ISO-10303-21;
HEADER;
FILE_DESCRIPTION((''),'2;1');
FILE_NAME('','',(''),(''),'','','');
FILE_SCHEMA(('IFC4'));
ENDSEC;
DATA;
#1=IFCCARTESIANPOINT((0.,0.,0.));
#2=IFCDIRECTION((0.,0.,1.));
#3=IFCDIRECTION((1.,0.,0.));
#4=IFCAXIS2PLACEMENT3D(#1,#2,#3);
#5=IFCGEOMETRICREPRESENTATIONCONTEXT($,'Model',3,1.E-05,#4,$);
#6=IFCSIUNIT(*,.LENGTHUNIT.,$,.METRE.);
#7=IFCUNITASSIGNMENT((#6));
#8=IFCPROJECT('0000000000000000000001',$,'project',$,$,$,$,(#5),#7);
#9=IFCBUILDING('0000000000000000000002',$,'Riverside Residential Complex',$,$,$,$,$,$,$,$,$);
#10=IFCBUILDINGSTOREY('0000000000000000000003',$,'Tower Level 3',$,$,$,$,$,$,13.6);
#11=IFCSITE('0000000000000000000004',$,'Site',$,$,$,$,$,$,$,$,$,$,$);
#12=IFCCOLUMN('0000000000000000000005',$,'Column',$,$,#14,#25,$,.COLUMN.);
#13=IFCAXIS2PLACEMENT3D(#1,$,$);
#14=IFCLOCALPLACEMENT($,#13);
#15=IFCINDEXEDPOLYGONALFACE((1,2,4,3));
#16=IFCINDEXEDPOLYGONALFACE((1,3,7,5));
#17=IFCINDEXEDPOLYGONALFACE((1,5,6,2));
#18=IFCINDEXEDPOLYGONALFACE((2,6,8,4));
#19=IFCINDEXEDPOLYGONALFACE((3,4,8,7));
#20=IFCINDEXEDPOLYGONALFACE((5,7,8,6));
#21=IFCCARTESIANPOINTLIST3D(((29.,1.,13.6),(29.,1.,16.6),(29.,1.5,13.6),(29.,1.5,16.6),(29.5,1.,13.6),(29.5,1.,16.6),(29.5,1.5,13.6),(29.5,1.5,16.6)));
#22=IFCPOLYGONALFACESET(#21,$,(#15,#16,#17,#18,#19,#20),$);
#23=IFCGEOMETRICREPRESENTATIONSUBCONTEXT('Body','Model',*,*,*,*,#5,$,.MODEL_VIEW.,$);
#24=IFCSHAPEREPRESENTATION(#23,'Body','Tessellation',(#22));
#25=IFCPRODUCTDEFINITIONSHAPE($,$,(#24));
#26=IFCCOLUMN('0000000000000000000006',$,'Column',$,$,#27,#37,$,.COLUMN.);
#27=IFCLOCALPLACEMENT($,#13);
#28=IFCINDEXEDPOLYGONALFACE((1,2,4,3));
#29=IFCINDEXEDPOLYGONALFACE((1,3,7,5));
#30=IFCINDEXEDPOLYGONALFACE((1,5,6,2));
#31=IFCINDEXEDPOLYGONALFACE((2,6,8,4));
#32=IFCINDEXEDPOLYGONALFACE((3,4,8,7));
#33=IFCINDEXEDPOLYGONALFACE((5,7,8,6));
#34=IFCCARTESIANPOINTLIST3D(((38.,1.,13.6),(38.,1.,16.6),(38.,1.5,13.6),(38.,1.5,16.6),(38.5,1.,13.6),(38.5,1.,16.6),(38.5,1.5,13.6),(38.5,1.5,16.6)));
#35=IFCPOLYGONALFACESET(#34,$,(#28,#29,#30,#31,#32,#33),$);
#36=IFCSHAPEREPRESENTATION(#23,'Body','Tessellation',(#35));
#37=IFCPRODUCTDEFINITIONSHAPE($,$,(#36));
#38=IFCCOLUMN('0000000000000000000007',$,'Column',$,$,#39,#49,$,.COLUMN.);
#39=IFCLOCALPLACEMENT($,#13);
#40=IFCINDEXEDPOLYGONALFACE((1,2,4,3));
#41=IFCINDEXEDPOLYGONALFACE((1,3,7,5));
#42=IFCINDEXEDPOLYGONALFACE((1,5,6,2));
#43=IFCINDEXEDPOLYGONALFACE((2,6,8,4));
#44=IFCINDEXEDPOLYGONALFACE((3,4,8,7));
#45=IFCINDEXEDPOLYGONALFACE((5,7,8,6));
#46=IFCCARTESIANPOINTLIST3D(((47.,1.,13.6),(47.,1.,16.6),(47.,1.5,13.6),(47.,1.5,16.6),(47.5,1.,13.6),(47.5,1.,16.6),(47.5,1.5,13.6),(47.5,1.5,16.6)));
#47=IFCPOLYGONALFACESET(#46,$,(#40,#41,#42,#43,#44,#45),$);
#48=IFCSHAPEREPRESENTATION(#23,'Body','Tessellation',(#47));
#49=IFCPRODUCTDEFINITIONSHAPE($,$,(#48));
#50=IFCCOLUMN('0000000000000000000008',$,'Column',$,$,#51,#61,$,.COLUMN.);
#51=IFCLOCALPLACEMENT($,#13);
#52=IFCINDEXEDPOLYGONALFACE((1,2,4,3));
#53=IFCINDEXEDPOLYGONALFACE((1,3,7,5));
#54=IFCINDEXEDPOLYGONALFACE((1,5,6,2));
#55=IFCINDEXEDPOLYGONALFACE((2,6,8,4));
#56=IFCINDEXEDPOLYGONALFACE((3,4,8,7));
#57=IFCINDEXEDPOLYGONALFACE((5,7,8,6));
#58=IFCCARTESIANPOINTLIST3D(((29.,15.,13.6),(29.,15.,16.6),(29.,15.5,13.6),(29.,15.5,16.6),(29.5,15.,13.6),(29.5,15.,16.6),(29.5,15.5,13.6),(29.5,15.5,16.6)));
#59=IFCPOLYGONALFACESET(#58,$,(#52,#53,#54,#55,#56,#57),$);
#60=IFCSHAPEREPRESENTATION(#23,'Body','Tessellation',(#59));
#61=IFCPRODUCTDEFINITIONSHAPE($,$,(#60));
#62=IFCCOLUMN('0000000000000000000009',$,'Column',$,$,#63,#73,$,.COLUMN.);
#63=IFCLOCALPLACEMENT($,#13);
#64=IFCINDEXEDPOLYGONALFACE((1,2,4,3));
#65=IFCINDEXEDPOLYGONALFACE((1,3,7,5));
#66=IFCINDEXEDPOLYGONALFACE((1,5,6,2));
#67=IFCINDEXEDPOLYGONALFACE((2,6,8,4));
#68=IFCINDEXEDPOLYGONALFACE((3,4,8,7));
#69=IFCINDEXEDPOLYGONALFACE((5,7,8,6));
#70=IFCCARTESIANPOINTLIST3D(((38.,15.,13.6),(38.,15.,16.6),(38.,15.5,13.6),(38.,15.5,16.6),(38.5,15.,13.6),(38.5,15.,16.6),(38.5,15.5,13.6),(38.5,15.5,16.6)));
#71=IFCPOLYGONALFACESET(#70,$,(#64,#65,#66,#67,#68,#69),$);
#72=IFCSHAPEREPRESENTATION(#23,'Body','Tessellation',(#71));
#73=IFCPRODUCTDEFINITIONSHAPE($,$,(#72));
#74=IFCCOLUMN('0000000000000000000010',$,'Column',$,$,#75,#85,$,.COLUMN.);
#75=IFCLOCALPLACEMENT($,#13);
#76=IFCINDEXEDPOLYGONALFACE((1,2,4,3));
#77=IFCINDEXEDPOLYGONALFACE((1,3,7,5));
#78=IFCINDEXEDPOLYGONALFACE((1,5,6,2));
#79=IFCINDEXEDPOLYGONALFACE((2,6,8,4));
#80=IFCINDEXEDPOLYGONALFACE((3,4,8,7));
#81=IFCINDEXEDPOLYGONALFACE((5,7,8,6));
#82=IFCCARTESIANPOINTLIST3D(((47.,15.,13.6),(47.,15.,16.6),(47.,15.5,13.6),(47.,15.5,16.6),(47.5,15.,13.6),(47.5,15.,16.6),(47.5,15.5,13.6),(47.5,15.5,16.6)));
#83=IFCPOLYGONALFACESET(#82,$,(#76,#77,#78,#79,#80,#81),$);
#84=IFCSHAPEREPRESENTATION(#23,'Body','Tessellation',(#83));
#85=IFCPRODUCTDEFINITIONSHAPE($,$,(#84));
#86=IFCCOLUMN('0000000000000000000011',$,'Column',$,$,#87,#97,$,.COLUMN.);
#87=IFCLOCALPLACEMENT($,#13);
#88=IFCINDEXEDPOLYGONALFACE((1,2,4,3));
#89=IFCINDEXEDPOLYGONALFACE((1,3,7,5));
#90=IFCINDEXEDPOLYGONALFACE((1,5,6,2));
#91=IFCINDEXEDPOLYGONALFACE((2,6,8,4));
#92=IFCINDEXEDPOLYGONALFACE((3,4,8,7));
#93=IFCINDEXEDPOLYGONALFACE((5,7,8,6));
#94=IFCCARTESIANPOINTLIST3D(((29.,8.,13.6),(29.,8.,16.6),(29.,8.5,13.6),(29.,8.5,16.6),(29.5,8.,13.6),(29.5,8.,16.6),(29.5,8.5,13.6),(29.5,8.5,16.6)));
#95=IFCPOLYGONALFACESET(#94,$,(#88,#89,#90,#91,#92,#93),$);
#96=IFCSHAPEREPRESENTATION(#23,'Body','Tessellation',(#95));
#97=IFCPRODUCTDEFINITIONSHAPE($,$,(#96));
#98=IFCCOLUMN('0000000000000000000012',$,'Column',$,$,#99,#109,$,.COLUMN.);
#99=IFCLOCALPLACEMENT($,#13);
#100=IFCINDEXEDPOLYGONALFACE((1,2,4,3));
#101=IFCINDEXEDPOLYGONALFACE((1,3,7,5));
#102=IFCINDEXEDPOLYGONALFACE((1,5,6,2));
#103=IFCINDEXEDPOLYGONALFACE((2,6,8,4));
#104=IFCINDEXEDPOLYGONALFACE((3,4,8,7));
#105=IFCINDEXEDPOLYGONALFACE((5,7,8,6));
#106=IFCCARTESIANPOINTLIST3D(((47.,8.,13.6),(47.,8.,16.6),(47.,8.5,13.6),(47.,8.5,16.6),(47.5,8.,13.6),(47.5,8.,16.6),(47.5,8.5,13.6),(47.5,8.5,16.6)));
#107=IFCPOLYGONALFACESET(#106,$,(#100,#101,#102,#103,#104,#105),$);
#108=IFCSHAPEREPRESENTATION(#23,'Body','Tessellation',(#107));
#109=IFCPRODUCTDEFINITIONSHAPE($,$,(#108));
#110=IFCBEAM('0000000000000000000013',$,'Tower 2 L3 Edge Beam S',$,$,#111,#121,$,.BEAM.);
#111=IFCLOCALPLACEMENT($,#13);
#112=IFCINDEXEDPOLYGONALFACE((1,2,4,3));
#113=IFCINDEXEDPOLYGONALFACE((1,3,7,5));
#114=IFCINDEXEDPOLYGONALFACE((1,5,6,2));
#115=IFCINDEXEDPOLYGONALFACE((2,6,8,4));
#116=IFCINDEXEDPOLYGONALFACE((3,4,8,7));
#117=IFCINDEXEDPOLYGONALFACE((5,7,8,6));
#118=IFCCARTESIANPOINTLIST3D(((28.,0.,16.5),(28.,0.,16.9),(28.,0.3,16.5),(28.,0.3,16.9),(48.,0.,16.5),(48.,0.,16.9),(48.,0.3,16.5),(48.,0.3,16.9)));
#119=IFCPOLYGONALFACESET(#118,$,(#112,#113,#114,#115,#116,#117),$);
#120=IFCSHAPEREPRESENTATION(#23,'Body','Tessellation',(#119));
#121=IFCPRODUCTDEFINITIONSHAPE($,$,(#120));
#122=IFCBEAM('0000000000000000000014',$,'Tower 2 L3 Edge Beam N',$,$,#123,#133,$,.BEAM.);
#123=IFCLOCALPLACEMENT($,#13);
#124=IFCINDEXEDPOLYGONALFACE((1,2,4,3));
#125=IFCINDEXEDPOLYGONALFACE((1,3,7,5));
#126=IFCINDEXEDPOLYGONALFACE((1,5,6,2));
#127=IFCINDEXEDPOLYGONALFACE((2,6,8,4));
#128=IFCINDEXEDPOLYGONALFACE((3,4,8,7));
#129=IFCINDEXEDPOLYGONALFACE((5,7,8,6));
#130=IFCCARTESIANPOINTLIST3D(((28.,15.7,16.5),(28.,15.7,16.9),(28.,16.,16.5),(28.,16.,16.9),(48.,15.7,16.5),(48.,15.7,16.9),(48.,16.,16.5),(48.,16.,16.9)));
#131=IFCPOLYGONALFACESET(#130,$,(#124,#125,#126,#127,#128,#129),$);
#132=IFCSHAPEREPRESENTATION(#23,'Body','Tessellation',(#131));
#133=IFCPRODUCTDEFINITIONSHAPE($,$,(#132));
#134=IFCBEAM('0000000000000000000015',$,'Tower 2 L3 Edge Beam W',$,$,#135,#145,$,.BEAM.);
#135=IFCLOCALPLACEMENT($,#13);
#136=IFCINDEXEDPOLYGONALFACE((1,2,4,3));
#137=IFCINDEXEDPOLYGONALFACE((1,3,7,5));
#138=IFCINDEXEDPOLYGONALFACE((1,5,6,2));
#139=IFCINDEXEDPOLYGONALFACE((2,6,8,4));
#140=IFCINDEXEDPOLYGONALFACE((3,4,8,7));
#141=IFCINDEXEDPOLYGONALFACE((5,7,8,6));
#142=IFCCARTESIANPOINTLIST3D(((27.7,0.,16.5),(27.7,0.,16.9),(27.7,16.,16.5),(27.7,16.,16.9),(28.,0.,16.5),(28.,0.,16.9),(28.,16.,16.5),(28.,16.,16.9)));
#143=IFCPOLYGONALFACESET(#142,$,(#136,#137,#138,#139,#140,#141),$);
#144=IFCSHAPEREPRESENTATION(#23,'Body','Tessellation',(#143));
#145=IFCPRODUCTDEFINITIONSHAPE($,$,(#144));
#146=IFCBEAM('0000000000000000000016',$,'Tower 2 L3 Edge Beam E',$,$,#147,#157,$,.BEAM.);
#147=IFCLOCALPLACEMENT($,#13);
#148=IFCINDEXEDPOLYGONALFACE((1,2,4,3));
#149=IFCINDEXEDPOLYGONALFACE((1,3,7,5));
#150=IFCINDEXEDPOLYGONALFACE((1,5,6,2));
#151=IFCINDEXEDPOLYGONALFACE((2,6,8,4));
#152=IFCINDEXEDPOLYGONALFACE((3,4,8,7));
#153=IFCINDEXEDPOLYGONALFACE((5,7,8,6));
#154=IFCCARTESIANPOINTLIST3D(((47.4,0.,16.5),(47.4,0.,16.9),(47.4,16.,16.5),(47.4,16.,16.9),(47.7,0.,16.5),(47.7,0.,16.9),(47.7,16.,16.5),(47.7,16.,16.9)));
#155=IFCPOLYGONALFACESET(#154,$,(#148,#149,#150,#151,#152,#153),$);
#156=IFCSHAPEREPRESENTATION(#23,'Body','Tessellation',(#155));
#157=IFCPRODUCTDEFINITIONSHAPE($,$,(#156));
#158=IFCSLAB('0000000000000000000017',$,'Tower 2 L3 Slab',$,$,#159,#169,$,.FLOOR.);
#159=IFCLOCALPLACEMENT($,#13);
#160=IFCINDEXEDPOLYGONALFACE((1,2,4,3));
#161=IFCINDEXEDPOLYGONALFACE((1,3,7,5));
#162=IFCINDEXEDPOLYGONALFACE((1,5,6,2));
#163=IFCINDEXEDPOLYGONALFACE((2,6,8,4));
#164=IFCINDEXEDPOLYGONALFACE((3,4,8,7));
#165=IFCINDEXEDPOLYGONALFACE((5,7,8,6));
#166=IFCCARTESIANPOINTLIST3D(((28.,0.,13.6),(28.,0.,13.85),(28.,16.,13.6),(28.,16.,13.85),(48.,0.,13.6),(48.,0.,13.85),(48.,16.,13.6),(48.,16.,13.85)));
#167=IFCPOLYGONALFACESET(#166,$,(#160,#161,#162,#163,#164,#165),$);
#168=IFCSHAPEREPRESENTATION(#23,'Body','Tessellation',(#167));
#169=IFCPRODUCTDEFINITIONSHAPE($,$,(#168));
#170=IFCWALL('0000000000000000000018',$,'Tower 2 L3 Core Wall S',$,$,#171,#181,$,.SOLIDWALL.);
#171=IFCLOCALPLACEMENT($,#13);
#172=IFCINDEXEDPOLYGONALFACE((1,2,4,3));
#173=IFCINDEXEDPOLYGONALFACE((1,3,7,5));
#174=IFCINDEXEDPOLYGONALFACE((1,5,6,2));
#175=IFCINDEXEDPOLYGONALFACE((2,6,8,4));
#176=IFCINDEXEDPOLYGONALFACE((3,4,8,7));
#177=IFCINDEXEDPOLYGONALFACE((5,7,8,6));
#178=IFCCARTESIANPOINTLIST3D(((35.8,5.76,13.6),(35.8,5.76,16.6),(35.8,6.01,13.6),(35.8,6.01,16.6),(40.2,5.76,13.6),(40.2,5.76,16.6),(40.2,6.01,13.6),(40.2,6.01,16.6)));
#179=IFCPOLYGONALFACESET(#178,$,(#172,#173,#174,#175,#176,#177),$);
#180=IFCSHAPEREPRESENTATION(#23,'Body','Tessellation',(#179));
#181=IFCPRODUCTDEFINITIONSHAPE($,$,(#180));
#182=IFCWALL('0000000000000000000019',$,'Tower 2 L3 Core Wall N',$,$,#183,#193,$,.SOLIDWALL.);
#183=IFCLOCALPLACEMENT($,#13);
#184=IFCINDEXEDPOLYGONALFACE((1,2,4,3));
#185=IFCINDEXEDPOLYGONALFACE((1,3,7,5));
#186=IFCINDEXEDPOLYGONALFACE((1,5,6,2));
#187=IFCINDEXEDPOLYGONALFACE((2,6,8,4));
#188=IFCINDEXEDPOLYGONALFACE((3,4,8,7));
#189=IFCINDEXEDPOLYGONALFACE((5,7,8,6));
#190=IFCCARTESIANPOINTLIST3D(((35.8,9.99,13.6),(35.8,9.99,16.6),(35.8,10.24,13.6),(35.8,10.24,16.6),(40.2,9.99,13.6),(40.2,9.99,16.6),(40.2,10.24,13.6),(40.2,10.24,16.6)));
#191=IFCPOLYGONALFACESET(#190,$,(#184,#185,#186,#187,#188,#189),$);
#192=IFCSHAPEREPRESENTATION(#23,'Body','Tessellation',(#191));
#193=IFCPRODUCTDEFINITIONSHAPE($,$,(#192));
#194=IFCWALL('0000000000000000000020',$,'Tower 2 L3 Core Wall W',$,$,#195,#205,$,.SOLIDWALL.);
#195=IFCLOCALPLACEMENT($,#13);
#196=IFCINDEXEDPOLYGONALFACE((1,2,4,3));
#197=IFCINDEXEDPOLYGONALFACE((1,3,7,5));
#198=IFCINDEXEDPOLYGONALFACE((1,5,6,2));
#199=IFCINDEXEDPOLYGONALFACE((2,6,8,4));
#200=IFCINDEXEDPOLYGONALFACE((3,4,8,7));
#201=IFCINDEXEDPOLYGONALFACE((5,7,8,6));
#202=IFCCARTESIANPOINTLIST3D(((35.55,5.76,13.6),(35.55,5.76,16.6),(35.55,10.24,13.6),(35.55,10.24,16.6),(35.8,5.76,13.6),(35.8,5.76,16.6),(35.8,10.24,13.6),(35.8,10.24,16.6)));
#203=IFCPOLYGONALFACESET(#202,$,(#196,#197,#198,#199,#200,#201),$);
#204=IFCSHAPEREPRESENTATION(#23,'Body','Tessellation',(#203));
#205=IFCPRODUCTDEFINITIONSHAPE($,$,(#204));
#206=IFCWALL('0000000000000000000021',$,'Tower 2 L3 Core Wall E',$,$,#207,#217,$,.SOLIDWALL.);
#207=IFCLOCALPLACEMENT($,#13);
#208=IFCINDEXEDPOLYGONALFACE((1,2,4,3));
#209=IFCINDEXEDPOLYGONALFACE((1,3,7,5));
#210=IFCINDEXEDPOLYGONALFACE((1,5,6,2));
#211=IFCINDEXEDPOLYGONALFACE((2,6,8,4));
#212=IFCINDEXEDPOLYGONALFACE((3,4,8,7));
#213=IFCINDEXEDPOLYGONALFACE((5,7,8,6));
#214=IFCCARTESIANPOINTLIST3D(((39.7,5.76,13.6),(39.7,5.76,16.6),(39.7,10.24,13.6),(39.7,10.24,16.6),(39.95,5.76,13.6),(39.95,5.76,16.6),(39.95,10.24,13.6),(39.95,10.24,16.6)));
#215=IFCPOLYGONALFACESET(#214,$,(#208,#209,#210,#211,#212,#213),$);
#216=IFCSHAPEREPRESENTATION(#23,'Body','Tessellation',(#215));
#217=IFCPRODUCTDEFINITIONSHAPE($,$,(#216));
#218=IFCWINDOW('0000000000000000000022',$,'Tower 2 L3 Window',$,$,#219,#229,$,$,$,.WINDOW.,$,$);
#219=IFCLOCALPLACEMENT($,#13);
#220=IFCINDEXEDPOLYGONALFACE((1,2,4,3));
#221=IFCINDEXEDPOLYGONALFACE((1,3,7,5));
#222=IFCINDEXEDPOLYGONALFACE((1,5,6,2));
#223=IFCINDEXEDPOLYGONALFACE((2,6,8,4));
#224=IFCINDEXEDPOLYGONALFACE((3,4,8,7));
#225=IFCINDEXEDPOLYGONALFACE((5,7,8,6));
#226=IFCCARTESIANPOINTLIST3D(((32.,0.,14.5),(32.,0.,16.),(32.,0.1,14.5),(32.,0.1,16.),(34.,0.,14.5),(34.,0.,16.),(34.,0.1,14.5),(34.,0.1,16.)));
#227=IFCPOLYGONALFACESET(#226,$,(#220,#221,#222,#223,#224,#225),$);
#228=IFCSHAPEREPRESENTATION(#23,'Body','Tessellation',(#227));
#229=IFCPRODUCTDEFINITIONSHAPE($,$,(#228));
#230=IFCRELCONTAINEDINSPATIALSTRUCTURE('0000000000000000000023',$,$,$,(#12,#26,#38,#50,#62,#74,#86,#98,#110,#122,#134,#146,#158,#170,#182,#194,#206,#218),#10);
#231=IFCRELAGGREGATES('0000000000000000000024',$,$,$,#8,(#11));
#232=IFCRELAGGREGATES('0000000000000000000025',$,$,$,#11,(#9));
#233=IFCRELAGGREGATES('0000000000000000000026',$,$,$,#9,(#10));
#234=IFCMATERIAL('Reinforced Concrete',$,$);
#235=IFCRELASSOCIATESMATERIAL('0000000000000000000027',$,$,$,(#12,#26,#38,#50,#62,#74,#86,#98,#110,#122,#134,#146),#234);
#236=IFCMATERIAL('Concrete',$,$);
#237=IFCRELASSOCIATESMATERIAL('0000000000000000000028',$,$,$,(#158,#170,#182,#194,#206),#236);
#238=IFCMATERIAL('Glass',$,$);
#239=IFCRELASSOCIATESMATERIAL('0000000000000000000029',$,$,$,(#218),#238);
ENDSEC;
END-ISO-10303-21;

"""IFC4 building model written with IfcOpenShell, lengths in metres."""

from ifc_helpers import new_model, si_unit, frame, origin_with_axes, place, context, subcontext, project, spatial, line, indexed_curve, outline, extrude, material, element, save


model = new_model("IFC4")

# Units and contexts
model_context = context("Model", 3, precision=1e-05, world=origin_with_axes())
body_context = subcontext(model_context, "Body", "Model", "MODEL_VIEW")
ifc_project = project(units=[si_unit("LENGTHUNIT", "METRE")], contexts=[model_context])

# Site, building, storey
site = spatial("IfcSite", under=ifc_project, Name="Site")
building = spatial("IfcBuilding", under=site, Name="Riverside Residential Complex")
storey = spatial("IfcBuildingStorey", under=building, Name="Tower Level 3", Elevation=13.6)

# Columns
ifc_material_1 = material(Name="Reinforced Concrete")
for number, where, z_axis, x_axis, name in (
    (1, (29.0, 1.0, 13.6), (0.0, 0.0, 1.0), (1.0, 0.0, 0.0), "Column"),
    (2, (38.0, 1.0, 13.6), (0.0, 0.0, 1.0), (1.0, 0.0, 0.0), "Column"),
    (3, (47.0, 1.0, 13.6), (0.0, 0.0, 1.0), (1.0, 0.0, 0.0), "Column"),
    (4, (29.0, 15.0, 13.6), (0.0, 0.0, 1.0), (1.0, 0.0, 0.0), "Column"),
    (5, (38.0, 15.0, 13.6), (0.0, 0.0, 1.0), (1.0, 0.0, 0.0), "Column"),
    (6, (47.0, 15.0, 13.6), (0.0, 0.0, 1.0), (1.0, 0.0, 0.0), "Column"),
    (7, (29.0, 8.0, 13.6), (0.0, 0.0, 1.0), (1.0, 0.0, 0.0), "Column"),
    (8, (47.0, 8.0, 13.6), (0.0, 0.0, 1.0), (1.0, 0.0, 0.0), "Column"),
):
    element("IfcColumn", number, at=place(None, frame(where, z_axis=z_axis, x_axis=x_axis)), inside=storey, material=ifc_material_1, Name=name, PredefinedType="COLUMN", context=body_context, shape_type="SweptSolid", body=[
        extrude(outline(indexed_curve([(0.0, 0.0), (0.5, 0.0), (0.5, 0.5), (0.0, 0.5)], segments=[line(1, 2, 3, 4, 1)])), origin_with_axes(), (0.0, 0.0, 1.0), 3.0),
    ])

# Beams
for number, where, z_axis, x_axis, name in (
    (9, (28.0, 0.0, 16.5), (0.0, 0.0, 1.0), (1.0, 0.0, 0.0), "Tower 2 L3 Edge Beam S"),
    (10, (28.0, 15.7, 16.5), (0.0, 0.0, 1.0), (1.0, 0.0, 0.0), "Tower 2 L3 Edge Beam N"),
):
    element("IfcBeam", number, at=place(None, frame(where, z_axis=z_axis, x_axis=x_axis)), inside=storey, material=ifc_material_1, Name=name, PredefinedType="BEAM", context=body_context, shape_type="SweptSolid", body=[
        extrude(outline(indexed_curve([(0.0, 0.0), (20.0, 0.0), (20.0, 0.3), (0.0, 0.3)], segments=[line(1, 2, 3, 4, 1)])), origin_with_axes(), (0.0, 0.0, 1.0), 0.4),
    ])
for number, where, z_axis, x_axis, name in (
    (11, (28.0, 0.0, 16.5), (0.0, 0.0, 1.0), (0.0, 1.0, 0.0), "Tower 2 L3 Edge Beam W"),
    (12, (47.7, 0.0, 16.5), (0.0, 0.0, 1.0), (0.0, 1.0, 0.0), "Tower 2 L3 Edge Beam E"),
):
    element("IfcBeam", number, at=place(None, frame(where, z_axis=z_axis, x_axis=x_axis)), inside=storey, material=ifc_material_1, Name=name, PredefinedType="BEAM", context=body_context, shape_type="SweptSolid", body=[
        extrude(outline(indexed_curve([(0.0, 0.0), (16.0, 0.0), (16.0, 0.3), (0.0, 0.3)], segments=[line(1, 2, 3, 4, 1)])), origin_with_axes(), (0.0, 0.0, 1.0), 0.4),
    ])

# Slab
ifc_material_2 = material(Name="Concrete")
slab_placement = place(None, frame((28.0, 0.0, 13.6), z_axis=(0.0, 0.0, 1.0), x_axis=(1.0, 0.0, 0.0)))
element("IfcSlab", 13, at=slab_placement, inside=storey, material=ifc_material_2, Name="Tower 2 L3 Slab", PredefinedType="FLOOR", context=body_context, shape_type="SweptSolid", body=[
    extrude(outline(indexed_curve([(0.0, 0.0), (20.0, 0.0), (20.0, 16.0), (0.0, 16.0)], segments=[line(1, 2, 3, 4, 1)])), origin_with_axes(), (0.0, 0.0, 1.0), 0.25),
])

# Walls
for number, where, z_axis, x_axis, name in (
    (14, (35.8, 5.76, 13.6), (0.0, 0.0, 1.0), (1.0, 0.0, 0.0), "Tower 2 L3 Core Wall S"),
    (15, (35.8, 9.99, 13.6), (0.0, 0.0, 1.0), (1.0, 0.0, 0.0), "Tower 2 L3 Core Wall N"),
):
    element("IfcWall", number, at=place(None, frame(where, z_axis=z_axis, x_axis=x_axis)), inside=storey, material=ifc_material_2, Name=name, PredefinedType="SOLIDWALL", context=body_context, shape_type="SweptSolid", body=[
        extrude(outline(indexed_curve([(0.0, 0.0), (4.4, 0.0), (4.4, 0.25), (0.0, 0.25)], segments=[line(1, 2, 3, 4, 1)])), origin_with_axes(), (0.0, 0.0, 1.0), 3.0),
    ])
for number, where, z_axis, x_axis, name in (
    (16, (35.8, 5.76, 13.6), (0.0, 0.0, 1.0), (0.0, 1.0, 0.0), "Tower 2 L3 Core Wall W"),
    (17, (39.95, 5.76, 13.6), (0.0, 0.0, 1.0), (0.0, 1.0, 0.0), "Tower 2 L3 Core Wall E"),
):
    element("IfcWall", number, at=place(None, frame(where, z_axis=z_axis, x_axis=x_axis)), inside=storey, material=ifc_material_2, Name=name, PredefinedType="SOLIDWALL", context=body_context, shape_type="SweptSolid", body=[
        extrude(outline(indexed_curve([(0.0, 0.0), (4.48, 0.0), (4.48, 0.25), (0.0, 0.25)], segments=[line(1, 2, 3, 4, 1)])), origin_with_axes(), (0.0, 0.0, 1.0), 3.0),
    ])

# Window
ifc_material_3 = material(Name="Glass")
for number, where, z_axis, x_axis, name in (
    (18, (32.0, 0.0, 14.5), (0.0, 0.0, 1.0), (1.0, 0.0, 0.0), "Tower 2 L3 Window"),
):
    element("IfcWindow", number, at=place(None, frame(where, z_axis=z_axis, x_axis=x_axis)), inside=storey, material=ifc_material_3, Name=name, PredefinedType="WINDOW", context=body_context, shape_type="SweptSolid", body=[
        extrude(outline(indexed_curve([(0.0, 0.0), (2.0, 0.0), (2.0, 0.1), (0.0, 0.1)], segments=[line(1, 2, 3, 4, 1)])), origin_with_axes(), (0.0, 0.0, 1.0), 1.5),
    ])

save(model, "model.ifc")
